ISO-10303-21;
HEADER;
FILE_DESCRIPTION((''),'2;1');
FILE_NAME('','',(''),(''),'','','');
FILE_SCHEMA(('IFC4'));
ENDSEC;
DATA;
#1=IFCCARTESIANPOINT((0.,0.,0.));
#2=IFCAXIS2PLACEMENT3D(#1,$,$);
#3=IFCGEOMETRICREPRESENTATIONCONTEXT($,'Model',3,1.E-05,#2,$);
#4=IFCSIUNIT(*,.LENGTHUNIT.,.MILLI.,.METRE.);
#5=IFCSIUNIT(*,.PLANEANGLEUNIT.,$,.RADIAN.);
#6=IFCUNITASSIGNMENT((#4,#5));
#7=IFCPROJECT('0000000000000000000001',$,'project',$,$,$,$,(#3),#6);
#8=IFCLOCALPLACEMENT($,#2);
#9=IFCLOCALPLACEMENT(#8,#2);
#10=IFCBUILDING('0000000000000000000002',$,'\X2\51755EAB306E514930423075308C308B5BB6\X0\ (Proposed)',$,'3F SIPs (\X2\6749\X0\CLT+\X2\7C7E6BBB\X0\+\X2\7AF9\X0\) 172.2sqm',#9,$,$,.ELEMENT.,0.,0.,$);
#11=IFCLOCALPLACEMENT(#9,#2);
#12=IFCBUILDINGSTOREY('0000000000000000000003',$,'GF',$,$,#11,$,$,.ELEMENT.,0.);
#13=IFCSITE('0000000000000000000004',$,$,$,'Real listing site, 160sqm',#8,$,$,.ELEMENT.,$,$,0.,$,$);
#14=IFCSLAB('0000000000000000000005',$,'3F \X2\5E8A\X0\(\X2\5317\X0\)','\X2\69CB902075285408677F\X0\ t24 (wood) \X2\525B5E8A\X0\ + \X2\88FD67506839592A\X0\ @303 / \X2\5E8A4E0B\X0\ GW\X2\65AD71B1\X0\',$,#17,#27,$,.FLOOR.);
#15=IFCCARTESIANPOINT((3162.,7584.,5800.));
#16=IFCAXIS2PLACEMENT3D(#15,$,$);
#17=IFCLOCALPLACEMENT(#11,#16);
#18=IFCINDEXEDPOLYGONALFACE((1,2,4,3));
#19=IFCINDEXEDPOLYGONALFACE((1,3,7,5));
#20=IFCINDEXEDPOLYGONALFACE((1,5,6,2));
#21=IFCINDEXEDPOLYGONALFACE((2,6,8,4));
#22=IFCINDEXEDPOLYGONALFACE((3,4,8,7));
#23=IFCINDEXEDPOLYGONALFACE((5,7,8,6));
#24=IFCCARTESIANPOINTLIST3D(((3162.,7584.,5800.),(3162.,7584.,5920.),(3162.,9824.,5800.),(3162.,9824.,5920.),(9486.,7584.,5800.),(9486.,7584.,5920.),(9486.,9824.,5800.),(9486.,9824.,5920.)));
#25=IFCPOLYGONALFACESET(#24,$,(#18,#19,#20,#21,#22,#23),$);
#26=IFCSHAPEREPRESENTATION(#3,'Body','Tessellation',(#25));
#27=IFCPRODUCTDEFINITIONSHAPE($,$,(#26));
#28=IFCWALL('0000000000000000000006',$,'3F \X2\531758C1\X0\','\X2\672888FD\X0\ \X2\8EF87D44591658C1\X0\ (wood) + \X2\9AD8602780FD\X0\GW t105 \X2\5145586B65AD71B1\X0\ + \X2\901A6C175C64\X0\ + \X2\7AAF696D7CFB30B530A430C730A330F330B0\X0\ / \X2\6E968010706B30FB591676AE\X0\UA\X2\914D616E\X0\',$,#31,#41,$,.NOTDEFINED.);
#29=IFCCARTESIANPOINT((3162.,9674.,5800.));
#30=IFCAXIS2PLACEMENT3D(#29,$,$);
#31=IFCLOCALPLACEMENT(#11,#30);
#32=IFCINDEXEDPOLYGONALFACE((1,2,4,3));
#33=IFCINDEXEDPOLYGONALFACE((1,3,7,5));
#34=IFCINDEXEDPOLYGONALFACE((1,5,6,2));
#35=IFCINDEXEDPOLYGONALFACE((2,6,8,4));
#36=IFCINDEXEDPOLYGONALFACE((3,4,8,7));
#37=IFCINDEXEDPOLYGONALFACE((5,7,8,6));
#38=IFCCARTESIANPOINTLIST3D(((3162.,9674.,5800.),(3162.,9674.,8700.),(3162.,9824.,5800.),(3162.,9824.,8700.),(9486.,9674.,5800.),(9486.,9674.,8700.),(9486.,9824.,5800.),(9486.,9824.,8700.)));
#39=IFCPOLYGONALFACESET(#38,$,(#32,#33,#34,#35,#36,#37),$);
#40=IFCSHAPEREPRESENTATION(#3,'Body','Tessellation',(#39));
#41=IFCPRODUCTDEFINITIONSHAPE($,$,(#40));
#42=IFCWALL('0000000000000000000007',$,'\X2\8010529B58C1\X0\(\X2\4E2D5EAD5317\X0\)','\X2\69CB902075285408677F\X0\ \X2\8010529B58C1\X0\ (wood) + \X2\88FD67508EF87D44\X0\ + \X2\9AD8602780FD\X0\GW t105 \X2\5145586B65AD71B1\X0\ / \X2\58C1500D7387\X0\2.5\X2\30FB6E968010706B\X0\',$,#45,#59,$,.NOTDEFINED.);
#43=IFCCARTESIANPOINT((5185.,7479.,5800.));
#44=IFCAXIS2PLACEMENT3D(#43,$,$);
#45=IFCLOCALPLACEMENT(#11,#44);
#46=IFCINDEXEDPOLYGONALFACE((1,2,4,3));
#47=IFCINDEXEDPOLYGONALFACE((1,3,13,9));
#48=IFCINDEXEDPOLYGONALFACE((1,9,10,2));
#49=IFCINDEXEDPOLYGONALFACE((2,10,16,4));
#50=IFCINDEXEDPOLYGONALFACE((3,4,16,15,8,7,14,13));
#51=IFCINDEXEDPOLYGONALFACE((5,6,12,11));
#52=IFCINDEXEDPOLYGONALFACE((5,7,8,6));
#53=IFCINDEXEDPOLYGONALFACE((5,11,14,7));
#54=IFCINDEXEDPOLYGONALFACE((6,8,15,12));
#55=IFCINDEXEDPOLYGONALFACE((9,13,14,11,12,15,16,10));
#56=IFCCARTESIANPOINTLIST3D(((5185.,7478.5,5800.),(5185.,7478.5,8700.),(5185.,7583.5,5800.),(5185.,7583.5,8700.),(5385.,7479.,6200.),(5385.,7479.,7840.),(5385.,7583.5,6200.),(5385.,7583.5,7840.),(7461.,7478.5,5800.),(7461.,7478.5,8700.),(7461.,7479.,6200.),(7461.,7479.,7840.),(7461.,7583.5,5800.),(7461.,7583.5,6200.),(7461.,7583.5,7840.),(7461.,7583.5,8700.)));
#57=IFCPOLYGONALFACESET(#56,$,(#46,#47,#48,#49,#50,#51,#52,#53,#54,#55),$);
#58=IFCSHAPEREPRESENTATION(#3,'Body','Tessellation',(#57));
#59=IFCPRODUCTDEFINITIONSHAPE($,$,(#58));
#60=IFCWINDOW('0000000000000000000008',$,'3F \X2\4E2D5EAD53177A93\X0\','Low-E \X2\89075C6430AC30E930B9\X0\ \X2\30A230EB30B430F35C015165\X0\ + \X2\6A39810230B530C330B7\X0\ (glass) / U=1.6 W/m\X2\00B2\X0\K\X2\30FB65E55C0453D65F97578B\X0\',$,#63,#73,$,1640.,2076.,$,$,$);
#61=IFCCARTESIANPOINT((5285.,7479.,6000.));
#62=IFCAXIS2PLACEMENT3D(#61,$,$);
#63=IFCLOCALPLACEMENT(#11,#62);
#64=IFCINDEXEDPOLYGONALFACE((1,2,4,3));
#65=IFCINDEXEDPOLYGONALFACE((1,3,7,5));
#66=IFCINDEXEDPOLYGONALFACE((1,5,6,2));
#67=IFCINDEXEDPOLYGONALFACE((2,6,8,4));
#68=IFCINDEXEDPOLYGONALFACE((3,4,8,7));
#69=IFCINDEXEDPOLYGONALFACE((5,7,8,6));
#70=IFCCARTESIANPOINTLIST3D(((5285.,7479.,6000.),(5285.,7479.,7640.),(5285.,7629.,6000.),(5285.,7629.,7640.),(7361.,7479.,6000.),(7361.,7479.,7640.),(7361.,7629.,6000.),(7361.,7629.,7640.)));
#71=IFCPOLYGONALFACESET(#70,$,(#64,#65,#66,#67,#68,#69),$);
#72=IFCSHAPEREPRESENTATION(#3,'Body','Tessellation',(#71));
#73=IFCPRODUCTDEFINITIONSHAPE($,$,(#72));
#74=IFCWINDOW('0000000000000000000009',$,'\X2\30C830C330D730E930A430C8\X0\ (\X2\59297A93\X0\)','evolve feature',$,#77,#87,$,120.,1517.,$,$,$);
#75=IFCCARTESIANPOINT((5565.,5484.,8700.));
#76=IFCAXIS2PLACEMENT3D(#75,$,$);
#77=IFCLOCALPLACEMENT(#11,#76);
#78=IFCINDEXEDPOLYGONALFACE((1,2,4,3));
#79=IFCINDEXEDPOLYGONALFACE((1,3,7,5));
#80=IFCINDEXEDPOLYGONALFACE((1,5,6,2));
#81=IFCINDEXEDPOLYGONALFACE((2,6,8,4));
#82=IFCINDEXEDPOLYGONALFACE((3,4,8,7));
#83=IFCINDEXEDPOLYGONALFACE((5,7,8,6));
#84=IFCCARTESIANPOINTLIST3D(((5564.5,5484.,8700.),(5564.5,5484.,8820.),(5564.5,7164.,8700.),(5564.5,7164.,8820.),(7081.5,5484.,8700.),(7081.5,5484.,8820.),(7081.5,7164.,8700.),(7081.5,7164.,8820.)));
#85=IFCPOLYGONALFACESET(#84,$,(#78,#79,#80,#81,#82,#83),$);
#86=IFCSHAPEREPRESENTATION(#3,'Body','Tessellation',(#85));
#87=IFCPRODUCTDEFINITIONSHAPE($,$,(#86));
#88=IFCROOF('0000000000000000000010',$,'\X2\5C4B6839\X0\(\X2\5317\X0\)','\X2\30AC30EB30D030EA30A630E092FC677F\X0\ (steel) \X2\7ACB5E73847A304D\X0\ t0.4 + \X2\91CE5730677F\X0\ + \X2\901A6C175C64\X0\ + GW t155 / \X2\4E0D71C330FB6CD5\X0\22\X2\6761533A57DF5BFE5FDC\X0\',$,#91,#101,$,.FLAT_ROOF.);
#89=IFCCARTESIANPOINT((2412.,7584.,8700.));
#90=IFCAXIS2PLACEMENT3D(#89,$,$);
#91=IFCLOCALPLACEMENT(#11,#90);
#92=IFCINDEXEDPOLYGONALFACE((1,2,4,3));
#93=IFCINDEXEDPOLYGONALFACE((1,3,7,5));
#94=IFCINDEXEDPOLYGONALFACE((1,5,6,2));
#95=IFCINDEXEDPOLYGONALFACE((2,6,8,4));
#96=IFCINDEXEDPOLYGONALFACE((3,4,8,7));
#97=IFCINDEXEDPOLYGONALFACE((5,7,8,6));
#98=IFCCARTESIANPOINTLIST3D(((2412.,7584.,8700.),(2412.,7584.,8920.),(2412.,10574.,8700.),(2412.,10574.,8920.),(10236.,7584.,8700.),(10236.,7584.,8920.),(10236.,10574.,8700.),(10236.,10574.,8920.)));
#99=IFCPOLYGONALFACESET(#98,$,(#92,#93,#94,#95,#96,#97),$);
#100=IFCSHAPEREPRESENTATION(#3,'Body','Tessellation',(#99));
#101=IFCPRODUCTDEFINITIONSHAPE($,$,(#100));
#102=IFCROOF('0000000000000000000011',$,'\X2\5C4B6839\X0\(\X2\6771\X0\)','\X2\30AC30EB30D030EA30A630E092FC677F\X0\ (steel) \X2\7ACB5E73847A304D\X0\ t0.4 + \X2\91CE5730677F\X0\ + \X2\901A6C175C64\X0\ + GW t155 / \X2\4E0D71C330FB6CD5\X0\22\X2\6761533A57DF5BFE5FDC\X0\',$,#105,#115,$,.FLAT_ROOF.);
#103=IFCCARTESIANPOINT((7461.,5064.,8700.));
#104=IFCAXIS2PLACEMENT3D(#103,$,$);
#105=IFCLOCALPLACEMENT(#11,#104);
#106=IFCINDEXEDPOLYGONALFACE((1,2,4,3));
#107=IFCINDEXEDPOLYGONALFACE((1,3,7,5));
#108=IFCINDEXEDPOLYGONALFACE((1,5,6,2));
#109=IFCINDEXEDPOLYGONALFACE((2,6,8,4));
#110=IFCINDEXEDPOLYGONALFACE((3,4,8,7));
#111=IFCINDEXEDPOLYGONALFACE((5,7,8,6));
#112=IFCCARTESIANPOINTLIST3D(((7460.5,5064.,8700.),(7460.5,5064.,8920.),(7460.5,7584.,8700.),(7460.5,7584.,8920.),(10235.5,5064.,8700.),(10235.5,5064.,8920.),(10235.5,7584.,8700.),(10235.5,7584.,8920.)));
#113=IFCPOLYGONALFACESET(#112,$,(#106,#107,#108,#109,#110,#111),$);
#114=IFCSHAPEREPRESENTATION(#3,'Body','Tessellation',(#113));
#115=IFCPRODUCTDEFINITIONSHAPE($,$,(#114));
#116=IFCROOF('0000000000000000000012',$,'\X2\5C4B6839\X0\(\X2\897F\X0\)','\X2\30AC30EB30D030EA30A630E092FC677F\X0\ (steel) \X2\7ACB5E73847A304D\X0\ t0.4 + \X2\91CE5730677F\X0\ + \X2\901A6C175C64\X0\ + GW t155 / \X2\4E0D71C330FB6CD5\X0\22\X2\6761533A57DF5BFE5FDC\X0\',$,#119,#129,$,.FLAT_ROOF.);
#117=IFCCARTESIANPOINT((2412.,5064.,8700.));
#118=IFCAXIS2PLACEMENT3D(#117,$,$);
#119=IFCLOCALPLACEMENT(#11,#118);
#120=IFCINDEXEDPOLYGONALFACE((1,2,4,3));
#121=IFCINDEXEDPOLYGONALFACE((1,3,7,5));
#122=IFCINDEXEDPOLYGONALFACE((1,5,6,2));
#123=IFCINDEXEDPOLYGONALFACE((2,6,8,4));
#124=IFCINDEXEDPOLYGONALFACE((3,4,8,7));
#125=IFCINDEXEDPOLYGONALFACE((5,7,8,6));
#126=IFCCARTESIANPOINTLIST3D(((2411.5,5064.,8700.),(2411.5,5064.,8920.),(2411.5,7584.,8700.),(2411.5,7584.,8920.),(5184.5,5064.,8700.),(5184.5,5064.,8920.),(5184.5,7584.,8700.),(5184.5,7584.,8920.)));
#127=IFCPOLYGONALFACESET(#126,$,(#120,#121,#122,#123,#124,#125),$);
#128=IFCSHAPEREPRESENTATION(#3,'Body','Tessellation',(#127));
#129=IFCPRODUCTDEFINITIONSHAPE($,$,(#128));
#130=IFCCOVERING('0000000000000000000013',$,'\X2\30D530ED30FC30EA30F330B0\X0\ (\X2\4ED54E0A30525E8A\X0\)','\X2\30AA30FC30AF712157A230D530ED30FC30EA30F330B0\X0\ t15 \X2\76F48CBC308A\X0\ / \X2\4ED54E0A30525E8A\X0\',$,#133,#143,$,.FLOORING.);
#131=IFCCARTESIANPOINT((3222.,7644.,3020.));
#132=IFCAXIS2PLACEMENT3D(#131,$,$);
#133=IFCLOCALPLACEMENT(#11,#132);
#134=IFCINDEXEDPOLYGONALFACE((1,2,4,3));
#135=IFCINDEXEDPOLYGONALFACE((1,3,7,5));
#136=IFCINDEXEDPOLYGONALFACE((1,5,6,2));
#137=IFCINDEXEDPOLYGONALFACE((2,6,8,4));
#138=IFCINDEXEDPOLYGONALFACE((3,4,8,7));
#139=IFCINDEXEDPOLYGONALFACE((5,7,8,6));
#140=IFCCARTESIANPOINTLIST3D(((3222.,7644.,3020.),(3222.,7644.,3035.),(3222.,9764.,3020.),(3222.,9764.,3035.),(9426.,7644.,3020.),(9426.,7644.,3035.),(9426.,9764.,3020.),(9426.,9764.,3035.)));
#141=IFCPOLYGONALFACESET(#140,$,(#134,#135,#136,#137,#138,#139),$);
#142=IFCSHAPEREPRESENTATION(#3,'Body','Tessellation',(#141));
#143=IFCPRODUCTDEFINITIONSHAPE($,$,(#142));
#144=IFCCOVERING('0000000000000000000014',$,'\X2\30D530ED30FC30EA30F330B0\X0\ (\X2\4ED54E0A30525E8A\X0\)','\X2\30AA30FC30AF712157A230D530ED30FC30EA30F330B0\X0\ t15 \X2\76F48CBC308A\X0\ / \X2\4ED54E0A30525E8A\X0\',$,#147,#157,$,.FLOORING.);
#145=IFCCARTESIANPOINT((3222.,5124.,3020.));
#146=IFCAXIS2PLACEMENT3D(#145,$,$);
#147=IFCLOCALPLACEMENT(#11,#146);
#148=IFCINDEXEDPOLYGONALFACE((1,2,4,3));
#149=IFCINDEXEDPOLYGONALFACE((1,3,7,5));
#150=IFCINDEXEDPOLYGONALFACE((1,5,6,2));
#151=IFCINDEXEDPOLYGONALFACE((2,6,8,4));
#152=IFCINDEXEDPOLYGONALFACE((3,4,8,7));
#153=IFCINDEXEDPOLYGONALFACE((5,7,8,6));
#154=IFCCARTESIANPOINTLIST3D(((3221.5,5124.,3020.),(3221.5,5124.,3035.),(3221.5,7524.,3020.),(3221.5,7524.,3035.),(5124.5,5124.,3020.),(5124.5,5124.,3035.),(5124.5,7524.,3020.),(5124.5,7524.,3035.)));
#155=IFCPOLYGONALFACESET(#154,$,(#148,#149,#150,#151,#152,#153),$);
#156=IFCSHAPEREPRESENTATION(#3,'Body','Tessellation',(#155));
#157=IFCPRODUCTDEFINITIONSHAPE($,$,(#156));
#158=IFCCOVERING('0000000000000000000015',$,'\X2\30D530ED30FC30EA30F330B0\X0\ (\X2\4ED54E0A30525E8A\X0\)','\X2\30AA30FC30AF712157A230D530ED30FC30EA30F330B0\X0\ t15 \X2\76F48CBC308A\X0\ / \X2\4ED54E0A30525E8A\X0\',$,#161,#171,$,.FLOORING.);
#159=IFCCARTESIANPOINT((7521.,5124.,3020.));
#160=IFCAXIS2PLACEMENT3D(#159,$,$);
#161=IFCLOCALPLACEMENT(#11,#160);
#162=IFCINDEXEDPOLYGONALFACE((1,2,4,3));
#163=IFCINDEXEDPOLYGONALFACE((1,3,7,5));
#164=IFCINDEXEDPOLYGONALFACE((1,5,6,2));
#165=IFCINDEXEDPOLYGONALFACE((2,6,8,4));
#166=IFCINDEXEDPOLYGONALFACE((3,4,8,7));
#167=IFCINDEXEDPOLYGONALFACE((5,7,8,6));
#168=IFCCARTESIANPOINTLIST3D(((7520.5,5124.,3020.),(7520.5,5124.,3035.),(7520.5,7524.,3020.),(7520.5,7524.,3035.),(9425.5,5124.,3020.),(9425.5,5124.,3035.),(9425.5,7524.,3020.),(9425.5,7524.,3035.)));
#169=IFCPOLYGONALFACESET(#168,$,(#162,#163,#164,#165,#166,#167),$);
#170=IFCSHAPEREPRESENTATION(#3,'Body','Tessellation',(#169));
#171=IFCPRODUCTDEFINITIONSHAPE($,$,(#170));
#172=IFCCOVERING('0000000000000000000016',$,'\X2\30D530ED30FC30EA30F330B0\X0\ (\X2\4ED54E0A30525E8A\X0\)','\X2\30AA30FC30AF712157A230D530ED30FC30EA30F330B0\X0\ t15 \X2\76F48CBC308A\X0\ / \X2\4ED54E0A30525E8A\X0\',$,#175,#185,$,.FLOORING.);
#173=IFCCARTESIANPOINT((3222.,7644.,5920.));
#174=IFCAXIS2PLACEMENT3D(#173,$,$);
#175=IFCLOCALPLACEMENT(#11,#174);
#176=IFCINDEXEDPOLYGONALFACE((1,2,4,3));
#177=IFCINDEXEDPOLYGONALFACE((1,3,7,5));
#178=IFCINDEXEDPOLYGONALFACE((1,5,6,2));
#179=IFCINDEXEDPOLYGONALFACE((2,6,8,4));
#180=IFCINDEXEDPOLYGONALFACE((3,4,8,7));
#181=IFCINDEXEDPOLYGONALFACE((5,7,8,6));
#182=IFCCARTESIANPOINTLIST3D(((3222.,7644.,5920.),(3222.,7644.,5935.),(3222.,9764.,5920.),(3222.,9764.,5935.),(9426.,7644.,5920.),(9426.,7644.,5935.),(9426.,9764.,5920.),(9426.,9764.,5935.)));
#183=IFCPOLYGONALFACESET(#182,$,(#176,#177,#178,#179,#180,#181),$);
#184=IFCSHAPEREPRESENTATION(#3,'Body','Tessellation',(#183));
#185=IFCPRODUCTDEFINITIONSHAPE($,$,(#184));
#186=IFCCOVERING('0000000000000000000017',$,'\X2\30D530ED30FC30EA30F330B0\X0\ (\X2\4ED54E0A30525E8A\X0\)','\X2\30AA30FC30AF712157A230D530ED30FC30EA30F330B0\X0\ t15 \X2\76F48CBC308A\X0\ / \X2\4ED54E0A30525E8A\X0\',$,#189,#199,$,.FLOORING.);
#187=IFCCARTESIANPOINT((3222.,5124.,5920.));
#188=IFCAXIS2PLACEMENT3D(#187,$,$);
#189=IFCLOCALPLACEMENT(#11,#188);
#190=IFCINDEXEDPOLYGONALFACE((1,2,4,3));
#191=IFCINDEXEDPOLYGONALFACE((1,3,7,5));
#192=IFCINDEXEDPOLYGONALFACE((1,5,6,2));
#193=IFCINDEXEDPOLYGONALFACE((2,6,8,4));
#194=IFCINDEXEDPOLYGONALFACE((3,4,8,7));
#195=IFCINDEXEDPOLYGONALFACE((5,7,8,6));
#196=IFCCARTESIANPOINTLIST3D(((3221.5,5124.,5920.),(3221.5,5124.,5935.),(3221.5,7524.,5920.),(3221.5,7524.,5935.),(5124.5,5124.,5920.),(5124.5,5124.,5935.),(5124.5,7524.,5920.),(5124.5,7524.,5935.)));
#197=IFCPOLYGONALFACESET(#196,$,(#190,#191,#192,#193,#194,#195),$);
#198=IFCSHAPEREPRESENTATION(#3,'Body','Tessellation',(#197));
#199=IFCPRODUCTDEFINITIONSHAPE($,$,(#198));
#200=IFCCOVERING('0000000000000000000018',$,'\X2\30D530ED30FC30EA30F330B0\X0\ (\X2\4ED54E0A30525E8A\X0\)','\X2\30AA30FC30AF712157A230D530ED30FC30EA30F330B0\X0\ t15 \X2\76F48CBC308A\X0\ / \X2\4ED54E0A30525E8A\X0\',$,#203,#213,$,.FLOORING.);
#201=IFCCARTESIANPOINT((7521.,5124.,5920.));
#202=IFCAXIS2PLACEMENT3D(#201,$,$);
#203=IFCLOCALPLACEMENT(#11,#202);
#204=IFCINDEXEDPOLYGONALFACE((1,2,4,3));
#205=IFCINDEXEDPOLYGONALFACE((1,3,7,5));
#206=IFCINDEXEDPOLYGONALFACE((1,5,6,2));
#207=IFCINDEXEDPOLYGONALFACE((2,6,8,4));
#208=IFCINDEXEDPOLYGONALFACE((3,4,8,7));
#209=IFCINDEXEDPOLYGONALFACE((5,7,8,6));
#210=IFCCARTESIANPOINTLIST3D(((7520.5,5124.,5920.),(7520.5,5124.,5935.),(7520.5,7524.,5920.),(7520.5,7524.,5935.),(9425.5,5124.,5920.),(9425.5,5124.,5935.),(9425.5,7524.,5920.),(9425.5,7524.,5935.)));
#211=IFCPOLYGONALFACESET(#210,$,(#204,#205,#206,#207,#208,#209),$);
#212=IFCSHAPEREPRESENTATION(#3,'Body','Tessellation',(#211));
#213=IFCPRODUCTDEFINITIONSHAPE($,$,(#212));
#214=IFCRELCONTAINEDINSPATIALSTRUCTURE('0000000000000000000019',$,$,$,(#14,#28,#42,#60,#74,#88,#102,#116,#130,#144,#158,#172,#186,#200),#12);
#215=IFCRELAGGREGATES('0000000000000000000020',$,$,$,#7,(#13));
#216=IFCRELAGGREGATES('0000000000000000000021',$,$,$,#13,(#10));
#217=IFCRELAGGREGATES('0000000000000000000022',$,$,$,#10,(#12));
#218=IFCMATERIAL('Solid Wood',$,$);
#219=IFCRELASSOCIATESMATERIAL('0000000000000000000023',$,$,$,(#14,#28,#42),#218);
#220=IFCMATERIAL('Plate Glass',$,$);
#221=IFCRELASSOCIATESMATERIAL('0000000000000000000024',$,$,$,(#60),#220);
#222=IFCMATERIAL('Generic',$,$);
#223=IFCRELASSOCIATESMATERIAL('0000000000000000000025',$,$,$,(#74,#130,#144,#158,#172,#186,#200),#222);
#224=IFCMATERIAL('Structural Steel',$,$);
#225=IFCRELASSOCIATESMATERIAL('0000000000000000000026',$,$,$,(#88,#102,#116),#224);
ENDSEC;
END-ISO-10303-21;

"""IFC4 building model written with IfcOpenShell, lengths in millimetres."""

from ifc_helpers import new_model, si_unit, frame, frame_2d, origin, place, context, project, spatial, rectangle, extrude, material, element, fill, save


model = new_model("IFC4")

# Units and contexts
model_context = context("Model", 3, precision=1e-05, world=origin())
ifc_project = project(units=[si_unit("LENGTHUNIT", "METRE", prefix="MILLI"), si_unit("PLANEANGLEUNIT", "RADIAN")], contexts=[model_context])

# Site, building, storey
site_placement = place(None, origin())
site = spatial("IfcSite", under=ifc_project, at=site_placement, ObjectType="Real listing site, 160sqm", CompositionType="ELEMENT", RefElevation=0.0)
building_placement = place(site_placement, origin())
building = spatial("IfcBuilding", under=site, at=building_placement, Name="兵庫の光あふれる家 (Proposed)", ObjectType="3F SIPs (杉CLT+籾殻+竹) 172.2sqm", CompositionType="ELEMENT", ElevationOfRefHeight=0.0, ElevationOfTerrain=0.0)
storey_placement = place(building_placement, origin())
storey = spatial("IfcBuildingStorey", under=building, at=storey_placement, Name="GF", CompositionType="ELEMENT", Elevation=0.0)

# Slab
ifc_material_1 = material(Name="Solid Wood")
slab_placement = place(storey_placement, frame((3162.0, 7584.0, 5800.0)))
element("IfcSlab", 1, at=slab_placement, inside=storey, material=ifc_material_1, Name="3F 床(北)", Description="構造用合板 t24 (wood) 剛床 + 製材根太 @303 / 床下 GW断熱", PredefinedType="FLOOR", context=model_context, shape_type="SweptSolid", body=[
    extrude(rectangle(XDim=6324.0, YDim=2240.0, at=frame_2d((3162.0, 1120.0))), frame((3162.0, 7584.0, 5800.0)), (0.0, 0.0, 1.0), 120.0),
])

# Wall
wall_1_placement = place(storey_placement, frame((3162.0, 9674.0, 5800.0)))
element("IfcWall", 2, at=wall_1_placement, inside=storey, material=ifc_material_1, Name="3F 北壁", Description="木製 軸組外壁 (wood) + 高性能GW t105 充填断熱 + 通気層 + 窯業系サイディング / 準耐火・外皮UA配慮", PredefinedType="NOTDEFINED", context=model_context, shape_type="SweptSolid", body=[
    extrude(rectangle(XDim=6324.0, YDim=150.0, at=frame_2d((3162.0, 75.0))), frame((3162.0, 9674.0, 5800.0)), (0.0, 0.0, 1.0), 2900.0),
])

# Wall, opening, window
wall_2_placement = place(storey_placement, frame((5185.0, 7479.0, 5800.0)))
wall_2 = element("IfcWall", 3, at=wall_2_placement, inside=storey, material=ifc_material_1, Name="耐力壁(中庭北)", Description="構造用合板 耐力壁 (wood) + 製材軸組 + 高性能GW t105 充填断熱 / 壁倍率2.5・準耐火", PredefinedType="NOTDEFINED", context=model_context, shape_type="SweptSolid", body=[
    extrude(rectangle(XDim=2276.0, YDim=105.0, at=frame_2d((1138.0, 52.0))), frame((5185.0, 7479.0, 5800.0)), (0.0, 0.0, 1.0), 2900.0),
])
opening_placement = place(storey_placement, frame((5285.0, 7479.0, 6000.0)))
opening = element("IfcOpeningElement", 4, at=opening_placement, cuts=wall_2, PredefinedType="NOTDEFINED", context=model_context, shape_type="SweptSolid", body=[
    extrude(rectangle(XDim=2076.0, YDim=150.0, at=frame_2d((1038.0, 75.0))), frame((5285.0, 7479.0, 6000.0)), (0.0, 0.0, 1.0), 1640.0),
])
ifc_material_2 = material(Name="Plate Glass")
window_1_placement = place(storey_placement, frame((5285.0, 7479.0, 6000.0)))
window_1 = element("IfcWindow", 5, at=window_1_placement, inside=storey, material=ifc_material_2, Name="3F 中庭北窓", Description="Low-E 複層ガラス アルゴン封入 + 樹脂サッシ (glass) / U=1.6 W/m²K・日射取得型", OverallHeight=1640.0, OverallWidth=2076.0, context=model_context, shape_type="SweptSolid", body=[
    extrude(rectangle(XDim=2076.0, YDim=150.0, at=frame_2d((1038.0, 75.0))), frame((5285.0, 7479.0, 6000.0)), (0.0, 0.0, 1.0), 1640.0),
])
fill(opening, window_1)

# Window
ifc_material_3 = material(Name="Generic")
window_2_placement = place(storey_placement, frame((5565.0, 5484.0, 8700.0)))
element("IfcWindow", 6, at=window_2_placement, inside=storey, material=ifc_material_3, Name="トップライト (天窓)", Description="evolve feature", OverallHeight=120.0, OverallWidth=1517.0, context=model_context, shape_type="SweptSolid", body=[
    extrude(rectangle(XDim=1517.0, YDim=1680.0, at=frame_2d((758.0, 840.0))), frame((5565.0, 5484.0, 8700.0)), (0.0, 0.0, 1.0), 120.0),
])

# Roofs
ifc_material_4 = material(Name="Structural Steel")
roof_1_placement = place(storey_placement, frame((2412.0, 7584.0, 8700.0)))
element("IfcRoof", 7, at=roof_1_placement, inside=storey, material=ifc_material_4, Name="屋根(北)", Description="ガルバリウム鋼板 (steel) 立平葺き t0.4 + 野地板 + 通気層 + GW t155 / 不燃・法22条区域対応", PredefinedType="FLAT_ROOF", context=model_context, shape_type="SweptSolid", body=[
    extrude(rectangle(XDim=7824.0, YDim=2990.0, at=frame_2d((3912.0, 1495.0))), frame((2412.0, 7584.0, 8700.0)), (0.0, 0.0, 1.0), 220.0),
])
roof_2_placement = place(storey_placement, frame((7461.0, 5064.0, 8700.0)))
element("IfcRoof", 8, at=roof_2_placement, inside=storey, material=ifc_material_4, Name="屋根(東)", Description="ガルバリウム鋼板 (steel) 立平葺き t0.4 + 野地板 + 通気層 + GW t155 / 不燃・法22条区域対応", PredefinedType="FLAT_ROOF", context=model_context, shape_type="SweptSolid", body=[
    extrude(rectangle(XDim=2775.0, YDim=2520.0, at=frame_2d((1387.0, 1260.0))), frame((7461.0, 5064.0, 8700.0)), (0.0, 0.0, 1.0), 220.0),
])
roof_3_placement = place(storey_placement, frame((2412.0, 5064.0, 8700.0)))
element("IfcRoof", 9, at=roof_3_placement, inside=storey, material=ifc_material_4, Name="屋根(西)", Description="ガルバリウム鋼板 (steel) 立平葺き t0.4 + 野地板 + 通気層 + GW t155 / 不燃・法22条区域対応", PredefinedType="FLAT_ROOF", context=model_context, shape_type="SweptSolid", body=[
    extrude(rectangle(XDim=2773.0, YDim=2520.0, at=frame_2d((1386.0, 1260.0))), frame((2412.0, 5064.0, 8700.0)), (0.0, 0.0, 1.0), 220.0),
])

# Coverings
covering_1_placement = place(storey_placement, frame((3222.0, 7644.0, 3020.0)))
element("IfcCovering", 10, at=covering_1_placement, inside=storey, material=ifc_material_3, Name="フローリング (仕上げ床)", Description="オーク無垢フローリング t15 直貼り / 仕上げ床", PredefinedType="FLOORING", context=model_context, shape_type="SweptSolid", body=[
    extrude(rectangle(XDim=6204.0, YDim=2120.0, at=frame_2d((3102.0, 1060.0))), frame((3222.0, 7644.0, 3020.0)), (0.0, 0.0, 1.0), 15.0),
])
covering_2_placement = place(storey_placement, frame((3222.0, 5124.0, 3020.0)))
element("IfcCovering", 11, at=covering_2_placement, inside=storey, material=ifc_material_3, Name="フローリング (仕上げ床)", Description="オーク無垢フローリング t15 直貼り / 仕上げ床", PredefinedType="FLOORING", context=model_context, shape_type="SweptSolid", body=[
    extrude(rectangle(XDim=1903.0, YDim=2400.0, at=frame_2d((951.0, 1200.0))), frame((3222.0, 5124.0, 3020.0)), (0.0, 0.0, 1.0), 15.0),
])
covering_3_placement = place(storey_placement, frame((7521.0, 5124.0, 3020.0)))
element("IfcCovering", 12, at=covering_3_placement, inside=storey, material=ifc_material_3, Name="フローリング (仕上げ床)", Description="オーク無垢フローリング t15 直貼り / 仕上げ床", PredefinedType="FLOORING", context=model_context, shape_type="SweptSolid", body=[
    extrude(rectangle(XDim=1905.0, YDim=2400.0, at=frame_2d((952.0, 1200.0))), frame((7521.0, 5124.0, 3020.0)), (0.0, 0.0, 1.0), 15.0),
])
covering_4_placement = place(storey_placement, frame((3222.0, 7644.0, 5920.0)))
element("IfcCovering", 13, at=covering_4_placement, inside=storey, material=ifc_material_3, Name="フローリング (仕上げ床)", Description="オーク無垢フローリング t15 直貼り / 仕上げ床", PredefinedType="FLOORING", context=model_context, shape_type="SweptSolid", body=[
    extrude(rectangle(XDim=6204.0, YDim=2120.0, at=frame_2d((3102.0, 1060.0))), frame((3222.0, 7644.0, 5920.0)), (0.0, 0.0, 1.0), 15.0),
])
covering_5_placement = place(storey_placement, frame((3222.0, 5124.0, 5920.0)))
element("IfcCovering", 14, at=covering_5_placement, inside=storey, material=ifc_material_3, Name="フローリング (仕上げ床)", Description="オーク無垢フローリング t15 直貼り / 仕上げ床", PredefinedType="FLOORING", context=model_context, shape_type="SweptSolid", body=[
    extrude(rectangle(XDim=1903.0, YDim=2400.0, at=frame_2d((951.0, 1200.0))), frame((3222.0, 5124.0, 5920.0)), (0.0, 0.0, 1.0), 15.0),
])
covering_6_placement = place(storey_placement, frame((7521.0, 5124.0, 5920.0)))
element("IfcCovering", 15, at=covering_6_placement, inside=storey, material=ifc_material_3, Name="フローリング (仕上げ床)", Description="オーク無垢フローリング t15 直貼り / 仕上げ床", PredefinedType="FLOORING", context=model_context, shape_type="SweptSolid", body=[
    extrude(rectangle(XDim=1905.0, YDim=2400.0, at=frame_2d((952.0, 1200.0))), frame((7521.0, 5124.0, 5920.0)), (0.0, 0.0, 1.0), 15.0),
])

save(model, "model.ifc")
